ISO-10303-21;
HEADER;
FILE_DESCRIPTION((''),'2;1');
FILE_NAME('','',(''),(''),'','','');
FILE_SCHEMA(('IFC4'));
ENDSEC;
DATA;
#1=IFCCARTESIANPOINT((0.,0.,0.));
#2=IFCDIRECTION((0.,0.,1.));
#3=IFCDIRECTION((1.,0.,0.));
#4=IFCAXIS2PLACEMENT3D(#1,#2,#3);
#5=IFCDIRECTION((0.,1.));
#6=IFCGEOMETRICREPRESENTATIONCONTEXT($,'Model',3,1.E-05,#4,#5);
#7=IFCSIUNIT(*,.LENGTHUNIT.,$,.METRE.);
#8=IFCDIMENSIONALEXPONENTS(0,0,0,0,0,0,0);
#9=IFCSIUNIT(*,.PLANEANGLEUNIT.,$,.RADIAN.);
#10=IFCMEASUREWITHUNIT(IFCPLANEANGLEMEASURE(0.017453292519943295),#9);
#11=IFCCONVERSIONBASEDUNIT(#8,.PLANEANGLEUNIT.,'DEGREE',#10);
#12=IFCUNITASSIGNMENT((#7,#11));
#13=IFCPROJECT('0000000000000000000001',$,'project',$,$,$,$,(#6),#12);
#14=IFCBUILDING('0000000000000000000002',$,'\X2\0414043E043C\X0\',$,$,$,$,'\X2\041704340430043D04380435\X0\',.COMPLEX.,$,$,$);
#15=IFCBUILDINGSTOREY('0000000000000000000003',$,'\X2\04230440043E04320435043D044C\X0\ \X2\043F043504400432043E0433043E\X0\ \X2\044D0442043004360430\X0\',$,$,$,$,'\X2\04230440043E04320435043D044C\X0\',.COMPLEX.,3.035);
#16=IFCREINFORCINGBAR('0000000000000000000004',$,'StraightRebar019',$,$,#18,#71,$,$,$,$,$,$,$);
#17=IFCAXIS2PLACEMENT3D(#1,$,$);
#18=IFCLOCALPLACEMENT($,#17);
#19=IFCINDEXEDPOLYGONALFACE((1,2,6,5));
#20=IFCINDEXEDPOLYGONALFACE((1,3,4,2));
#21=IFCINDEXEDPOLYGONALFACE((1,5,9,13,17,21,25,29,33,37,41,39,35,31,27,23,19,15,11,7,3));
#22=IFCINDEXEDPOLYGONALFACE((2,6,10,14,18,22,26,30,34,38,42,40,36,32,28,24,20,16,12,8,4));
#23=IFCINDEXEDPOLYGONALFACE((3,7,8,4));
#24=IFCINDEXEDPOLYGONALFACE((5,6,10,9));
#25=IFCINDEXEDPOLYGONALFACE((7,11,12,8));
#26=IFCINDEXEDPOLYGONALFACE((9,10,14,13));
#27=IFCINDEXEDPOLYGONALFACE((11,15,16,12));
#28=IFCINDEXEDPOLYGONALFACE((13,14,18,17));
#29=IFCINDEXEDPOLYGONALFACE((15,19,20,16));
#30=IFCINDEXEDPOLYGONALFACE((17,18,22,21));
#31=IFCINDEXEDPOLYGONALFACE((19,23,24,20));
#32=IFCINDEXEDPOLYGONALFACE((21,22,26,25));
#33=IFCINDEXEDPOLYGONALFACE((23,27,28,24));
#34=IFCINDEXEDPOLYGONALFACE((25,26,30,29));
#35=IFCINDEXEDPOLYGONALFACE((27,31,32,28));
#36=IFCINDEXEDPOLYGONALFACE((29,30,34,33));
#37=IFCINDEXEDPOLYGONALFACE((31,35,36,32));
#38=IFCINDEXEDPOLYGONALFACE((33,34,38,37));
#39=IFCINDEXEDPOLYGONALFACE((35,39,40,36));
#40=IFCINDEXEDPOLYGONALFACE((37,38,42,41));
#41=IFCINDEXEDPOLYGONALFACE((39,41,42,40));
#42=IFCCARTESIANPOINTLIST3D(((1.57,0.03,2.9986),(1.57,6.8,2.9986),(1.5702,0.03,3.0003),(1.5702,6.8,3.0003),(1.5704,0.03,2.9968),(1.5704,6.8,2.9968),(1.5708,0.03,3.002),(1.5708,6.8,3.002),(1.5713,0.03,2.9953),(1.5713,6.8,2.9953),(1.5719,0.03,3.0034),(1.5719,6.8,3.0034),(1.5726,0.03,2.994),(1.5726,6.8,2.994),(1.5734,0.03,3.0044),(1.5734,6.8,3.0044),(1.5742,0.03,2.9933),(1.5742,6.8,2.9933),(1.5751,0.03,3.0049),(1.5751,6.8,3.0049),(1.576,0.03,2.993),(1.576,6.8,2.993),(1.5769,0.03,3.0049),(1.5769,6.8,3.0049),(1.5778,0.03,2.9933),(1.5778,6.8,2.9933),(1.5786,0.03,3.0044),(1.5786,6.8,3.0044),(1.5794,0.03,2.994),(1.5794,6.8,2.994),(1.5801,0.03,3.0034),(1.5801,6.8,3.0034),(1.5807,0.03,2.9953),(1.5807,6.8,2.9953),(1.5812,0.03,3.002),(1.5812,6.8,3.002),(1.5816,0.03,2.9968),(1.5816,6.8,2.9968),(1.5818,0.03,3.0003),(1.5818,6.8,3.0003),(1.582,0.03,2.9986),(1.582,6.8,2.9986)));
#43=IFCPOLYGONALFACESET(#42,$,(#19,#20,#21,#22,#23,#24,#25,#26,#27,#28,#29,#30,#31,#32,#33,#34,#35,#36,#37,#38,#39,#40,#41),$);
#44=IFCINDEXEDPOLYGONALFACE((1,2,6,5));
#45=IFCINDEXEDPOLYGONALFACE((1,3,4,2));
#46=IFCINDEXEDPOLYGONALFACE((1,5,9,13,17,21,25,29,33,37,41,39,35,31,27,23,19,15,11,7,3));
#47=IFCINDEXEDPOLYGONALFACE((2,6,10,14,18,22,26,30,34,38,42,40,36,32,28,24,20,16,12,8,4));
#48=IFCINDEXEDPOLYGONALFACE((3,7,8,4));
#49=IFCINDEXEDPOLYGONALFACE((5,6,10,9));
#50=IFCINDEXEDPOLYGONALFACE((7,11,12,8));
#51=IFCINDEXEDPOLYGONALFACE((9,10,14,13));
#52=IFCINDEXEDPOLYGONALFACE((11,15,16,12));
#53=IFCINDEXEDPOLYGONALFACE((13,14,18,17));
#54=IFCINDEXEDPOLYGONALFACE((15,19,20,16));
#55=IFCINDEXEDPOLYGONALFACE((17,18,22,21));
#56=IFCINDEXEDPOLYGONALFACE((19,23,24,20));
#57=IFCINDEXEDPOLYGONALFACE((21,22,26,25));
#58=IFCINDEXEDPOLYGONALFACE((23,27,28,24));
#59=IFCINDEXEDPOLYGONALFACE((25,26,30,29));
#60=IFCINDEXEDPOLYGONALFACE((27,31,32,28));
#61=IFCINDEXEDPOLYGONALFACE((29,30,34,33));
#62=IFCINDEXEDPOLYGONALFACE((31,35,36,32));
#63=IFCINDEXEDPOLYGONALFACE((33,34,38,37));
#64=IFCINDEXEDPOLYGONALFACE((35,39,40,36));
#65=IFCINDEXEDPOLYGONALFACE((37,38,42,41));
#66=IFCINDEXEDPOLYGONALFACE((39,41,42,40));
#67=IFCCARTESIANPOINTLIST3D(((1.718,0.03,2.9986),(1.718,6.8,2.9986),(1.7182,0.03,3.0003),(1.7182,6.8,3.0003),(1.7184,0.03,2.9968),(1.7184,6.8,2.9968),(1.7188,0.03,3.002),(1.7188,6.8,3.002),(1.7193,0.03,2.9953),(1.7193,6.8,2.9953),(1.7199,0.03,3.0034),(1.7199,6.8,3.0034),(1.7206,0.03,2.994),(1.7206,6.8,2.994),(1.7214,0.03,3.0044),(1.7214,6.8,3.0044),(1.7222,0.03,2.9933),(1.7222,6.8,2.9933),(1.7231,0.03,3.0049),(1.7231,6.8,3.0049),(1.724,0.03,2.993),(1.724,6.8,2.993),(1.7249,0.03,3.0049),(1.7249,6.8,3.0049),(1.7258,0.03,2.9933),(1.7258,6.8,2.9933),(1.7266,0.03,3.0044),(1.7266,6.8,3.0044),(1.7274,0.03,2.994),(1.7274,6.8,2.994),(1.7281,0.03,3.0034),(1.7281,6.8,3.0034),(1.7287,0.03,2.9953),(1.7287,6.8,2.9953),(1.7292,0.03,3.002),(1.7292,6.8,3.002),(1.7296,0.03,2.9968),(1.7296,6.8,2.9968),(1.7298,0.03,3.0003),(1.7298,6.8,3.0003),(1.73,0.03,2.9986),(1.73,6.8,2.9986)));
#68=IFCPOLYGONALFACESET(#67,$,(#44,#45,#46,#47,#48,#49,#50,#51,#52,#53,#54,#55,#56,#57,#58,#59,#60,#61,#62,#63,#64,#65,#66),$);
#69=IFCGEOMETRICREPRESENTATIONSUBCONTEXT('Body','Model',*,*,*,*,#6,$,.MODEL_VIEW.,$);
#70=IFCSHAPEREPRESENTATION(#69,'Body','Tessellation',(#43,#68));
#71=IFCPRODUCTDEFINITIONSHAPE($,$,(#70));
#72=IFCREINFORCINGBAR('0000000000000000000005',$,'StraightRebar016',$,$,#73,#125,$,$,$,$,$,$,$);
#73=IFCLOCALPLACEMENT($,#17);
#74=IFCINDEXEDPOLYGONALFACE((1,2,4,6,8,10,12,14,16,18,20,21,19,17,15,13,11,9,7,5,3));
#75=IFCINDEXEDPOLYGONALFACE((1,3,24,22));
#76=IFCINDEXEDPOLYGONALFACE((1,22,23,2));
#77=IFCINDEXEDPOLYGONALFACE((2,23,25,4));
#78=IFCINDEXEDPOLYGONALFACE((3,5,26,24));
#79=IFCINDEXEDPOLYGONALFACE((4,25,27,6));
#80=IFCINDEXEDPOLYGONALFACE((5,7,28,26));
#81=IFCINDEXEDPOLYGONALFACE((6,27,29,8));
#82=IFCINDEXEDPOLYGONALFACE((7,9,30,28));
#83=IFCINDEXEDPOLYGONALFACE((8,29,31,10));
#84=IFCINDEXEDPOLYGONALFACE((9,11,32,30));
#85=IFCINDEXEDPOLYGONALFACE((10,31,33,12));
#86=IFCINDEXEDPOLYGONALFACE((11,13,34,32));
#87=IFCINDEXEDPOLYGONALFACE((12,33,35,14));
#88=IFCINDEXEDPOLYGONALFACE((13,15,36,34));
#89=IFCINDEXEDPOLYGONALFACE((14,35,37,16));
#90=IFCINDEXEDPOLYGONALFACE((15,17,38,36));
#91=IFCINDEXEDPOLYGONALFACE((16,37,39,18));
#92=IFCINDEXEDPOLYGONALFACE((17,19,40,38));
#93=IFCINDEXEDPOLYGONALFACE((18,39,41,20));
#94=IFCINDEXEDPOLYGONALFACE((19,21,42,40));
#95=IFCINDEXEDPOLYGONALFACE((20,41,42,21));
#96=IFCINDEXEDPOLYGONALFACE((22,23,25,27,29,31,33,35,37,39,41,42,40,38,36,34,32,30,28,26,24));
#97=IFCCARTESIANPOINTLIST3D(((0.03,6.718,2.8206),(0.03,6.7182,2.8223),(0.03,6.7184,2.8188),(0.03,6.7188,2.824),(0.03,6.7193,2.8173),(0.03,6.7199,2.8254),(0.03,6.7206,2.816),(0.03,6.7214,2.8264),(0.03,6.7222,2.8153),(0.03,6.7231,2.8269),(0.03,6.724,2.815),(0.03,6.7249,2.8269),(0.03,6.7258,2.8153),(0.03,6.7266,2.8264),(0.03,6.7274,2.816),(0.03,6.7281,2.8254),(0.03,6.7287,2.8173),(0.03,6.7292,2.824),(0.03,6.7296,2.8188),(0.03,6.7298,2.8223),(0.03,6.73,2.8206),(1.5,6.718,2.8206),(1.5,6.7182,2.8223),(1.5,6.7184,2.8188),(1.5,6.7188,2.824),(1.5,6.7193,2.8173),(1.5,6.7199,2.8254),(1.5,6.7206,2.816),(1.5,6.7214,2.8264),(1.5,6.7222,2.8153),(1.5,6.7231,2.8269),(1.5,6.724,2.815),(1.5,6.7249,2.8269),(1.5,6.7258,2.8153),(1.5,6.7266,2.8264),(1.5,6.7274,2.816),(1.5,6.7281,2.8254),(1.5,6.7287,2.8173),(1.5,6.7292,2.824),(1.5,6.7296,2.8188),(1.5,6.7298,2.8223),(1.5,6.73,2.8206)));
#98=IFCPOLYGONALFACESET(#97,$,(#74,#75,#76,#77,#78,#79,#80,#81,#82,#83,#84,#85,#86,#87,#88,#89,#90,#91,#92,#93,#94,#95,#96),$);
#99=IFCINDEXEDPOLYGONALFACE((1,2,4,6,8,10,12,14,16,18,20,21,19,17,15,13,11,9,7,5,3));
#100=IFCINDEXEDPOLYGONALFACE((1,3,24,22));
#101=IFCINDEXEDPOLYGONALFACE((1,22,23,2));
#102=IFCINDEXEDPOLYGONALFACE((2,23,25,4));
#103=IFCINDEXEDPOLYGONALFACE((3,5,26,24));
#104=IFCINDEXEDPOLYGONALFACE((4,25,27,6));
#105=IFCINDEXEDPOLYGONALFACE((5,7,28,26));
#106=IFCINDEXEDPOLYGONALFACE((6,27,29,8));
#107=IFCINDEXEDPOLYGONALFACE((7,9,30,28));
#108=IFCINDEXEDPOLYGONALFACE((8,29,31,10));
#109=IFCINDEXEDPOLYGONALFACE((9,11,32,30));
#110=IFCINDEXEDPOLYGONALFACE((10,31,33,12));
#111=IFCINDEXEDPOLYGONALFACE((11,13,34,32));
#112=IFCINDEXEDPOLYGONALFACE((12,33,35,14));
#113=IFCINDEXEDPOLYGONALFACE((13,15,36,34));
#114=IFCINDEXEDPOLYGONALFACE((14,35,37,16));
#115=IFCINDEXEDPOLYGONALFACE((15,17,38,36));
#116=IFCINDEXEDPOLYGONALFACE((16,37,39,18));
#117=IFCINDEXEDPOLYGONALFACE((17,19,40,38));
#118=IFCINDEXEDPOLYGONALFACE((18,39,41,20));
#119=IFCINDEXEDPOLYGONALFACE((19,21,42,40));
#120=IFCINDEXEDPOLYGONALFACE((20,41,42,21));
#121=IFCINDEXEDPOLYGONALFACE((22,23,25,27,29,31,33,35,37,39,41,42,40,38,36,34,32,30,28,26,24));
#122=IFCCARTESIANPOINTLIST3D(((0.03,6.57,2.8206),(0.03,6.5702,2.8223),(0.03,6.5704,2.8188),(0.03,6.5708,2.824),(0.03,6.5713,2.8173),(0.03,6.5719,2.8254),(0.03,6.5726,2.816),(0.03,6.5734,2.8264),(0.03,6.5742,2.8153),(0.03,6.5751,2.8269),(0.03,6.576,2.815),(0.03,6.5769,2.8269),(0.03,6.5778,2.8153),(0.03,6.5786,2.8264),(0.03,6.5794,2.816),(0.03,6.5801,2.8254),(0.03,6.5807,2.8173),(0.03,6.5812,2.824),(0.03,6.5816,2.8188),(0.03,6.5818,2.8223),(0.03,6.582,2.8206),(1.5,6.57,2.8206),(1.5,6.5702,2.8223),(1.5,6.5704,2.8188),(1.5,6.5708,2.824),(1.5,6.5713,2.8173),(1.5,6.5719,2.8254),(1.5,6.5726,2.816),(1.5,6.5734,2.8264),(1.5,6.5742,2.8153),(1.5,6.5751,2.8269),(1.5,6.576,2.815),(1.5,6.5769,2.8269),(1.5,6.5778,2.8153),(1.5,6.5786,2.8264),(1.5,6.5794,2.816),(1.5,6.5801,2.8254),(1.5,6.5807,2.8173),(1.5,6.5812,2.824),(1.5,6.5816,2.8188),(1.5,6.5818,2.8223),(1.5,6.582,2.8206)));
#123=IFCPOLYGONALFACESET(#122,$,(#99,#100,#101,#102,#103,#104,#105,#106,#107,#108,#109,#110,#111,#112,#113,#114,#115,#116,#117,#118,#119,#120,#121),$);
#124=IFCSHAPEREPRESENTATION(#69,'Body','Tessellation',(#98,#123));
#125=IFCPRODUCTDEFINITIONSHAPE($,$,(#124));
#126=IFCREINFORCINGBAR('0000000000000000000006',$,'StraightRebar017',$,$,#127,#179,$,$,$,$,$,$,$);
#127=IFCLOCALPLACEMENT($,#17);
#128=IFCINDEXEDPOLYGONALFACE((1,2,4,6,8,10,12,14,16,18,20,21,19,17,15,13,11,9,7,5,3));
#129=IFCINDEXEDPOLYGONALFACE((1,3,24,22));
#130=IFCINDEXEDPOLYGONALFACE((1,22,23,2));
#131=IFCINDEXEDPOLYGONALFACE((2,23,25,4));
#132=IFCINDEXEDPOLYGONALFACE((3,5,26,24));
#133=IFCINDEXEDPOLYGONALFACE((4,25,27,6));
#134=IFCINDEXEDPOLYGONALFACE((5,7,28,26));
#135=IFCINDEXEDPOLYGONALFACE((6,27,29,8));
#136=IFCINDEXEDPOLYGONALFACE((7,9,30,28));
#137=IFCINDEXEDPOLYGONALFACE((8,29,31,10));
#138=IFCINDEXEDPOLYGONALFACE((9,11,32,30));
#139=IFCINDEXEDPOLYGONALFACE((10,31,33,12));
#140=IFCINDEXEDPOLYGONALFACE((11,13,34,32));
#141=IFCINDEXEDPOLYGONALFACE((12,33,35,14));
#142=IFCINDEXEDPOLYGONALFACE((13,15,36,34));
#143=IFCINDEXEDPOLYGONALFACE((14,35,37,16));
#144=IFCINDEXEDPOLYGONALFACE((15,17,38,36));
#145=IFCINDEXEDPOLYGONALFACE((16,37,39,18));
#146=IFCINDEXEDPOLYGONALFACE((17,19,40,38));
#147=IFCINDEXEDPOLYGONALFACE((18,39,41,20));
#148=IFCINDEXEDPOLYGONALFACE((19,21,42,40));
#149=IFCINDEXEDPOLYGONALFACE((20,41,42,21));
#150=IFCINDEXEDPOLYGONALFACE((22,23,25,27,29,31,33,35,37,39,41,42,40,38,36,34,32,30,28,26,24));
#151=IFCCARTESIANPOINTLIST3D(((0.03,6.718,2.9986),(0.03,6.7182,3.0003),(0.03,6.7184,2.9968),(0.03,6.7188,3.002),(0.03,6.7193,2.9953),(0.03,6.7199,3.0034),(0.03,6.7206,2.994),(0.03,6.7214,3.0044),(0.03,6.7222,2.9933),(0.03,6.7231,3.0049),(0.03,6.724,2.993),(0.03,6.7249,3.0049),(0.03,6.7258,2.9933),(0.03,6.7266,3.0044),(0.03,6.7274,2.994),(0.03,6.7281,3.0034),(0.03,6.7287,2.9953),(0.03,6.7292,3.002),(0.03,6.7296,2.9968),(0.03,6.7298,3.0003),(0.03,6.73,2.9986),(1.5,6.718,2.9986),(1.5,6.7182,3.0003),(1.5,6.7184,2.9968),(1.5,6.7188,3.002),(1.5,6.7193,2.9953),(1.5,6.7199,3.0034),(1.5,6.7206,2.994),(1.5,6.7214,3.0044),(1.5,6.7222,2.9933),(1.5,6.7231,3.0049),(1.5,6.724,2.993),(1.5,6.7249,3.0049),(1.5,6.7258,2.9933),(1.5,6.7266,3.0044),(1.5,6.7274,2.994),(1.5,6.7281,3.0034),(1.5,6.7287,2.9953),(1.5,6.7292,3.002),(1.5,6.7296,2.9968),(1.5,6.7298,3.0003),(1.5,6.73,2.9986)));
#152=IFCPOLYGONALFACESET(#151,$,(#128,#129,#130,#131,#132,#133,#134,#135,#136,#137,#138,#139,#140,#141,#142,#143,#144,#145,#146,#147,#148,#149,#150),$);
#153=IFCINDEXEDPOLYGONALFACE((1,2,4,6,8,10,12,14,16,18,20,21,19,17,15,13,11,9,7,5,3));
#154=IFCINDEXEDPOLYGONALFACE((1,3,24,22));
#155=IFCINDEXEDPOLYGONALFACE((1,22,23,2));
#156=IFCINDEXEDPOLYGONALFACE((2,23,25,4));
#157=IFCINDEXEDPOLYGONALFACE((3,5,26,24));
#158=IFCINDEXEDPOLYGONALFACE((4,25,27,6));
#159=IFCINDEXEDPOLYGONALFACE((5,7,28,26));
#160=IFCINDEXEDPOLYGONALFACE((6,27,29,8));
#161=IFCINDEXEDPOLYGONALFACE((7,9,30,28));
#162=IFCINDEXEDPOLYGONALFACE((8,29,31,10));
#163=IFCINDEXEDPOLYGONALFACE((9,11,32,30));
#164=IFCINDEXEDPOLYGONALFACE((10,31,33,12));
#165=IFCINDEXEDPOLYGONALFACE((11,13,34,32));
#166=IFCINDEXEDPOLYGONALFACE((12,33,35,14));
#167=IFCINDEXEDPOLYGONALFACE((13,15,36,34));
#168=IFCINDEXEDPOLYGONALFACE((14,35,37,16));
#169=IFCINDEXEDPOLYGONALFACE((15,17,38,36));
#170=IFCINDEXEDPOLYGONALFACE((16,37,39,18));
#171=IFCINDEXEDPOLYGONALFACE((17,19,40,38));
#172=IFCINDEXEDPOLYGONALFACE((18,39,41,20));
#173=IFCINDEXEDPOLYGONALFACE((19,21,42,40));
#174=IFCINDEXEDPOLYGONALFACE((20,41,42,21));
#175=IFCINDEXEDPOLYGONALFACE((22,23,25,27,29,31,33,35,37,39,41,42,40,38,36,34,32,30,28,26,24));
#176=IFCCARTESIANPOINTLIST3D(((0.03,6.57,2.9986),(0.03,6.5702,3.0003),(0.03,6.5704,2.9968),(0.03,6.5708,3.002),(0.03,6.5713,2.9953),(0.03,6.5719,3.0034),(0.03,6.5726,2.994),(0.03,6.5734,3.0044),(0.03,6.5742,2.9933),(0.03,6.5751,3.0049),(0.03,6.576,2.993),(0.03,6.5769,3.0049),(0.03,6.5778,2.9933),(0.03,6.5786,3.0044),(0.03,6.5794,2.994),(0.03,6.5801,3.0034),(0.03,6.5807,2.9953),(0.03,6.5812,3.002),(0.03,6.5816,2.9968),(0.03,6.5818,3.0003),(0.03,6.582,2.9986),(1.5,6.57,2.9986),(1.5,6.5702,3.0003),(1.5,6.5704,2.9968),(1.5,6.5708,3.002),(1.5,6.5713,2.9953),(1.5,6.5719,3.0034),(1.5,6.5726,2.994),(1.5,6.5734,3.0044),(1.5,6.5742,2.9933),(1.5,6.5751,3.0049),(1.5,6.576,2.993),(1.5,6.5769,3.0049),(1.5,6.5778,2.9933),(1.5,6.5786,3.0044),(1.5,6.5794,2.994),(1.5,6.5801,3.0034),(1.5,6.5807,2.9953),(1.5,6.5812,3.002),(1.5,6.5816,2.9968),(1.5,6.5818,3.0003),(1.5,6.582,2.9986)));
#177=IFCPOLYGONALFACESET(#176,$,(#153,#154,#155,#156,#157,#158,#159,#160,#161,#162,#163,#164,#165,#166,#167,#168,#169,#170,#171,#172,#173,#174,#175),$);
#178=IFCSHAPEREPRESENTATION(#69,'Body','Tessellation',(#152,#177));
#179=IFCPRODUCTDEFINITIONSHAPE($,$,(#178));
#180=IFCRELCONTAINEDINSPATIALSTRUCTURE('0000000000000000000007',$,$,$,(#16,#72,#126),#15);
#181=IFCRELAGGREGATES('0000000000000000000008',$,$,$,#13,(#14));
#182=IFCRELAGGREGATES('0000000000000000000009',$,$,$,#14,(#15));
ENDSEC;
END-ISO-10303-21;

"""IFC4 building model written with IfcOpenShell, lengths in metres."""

from ifc_helpers import new_model, entity, si_unit, converted_unit, direction, origin_with_axes, place, context, subcontext, project, spatial, element, save


model = new_model("IFC4")

# Units and contexts
model_context = context("Model", 3, precision=1e-05, world=origin_with_axes(), true_north=direction((0.0, 1.0)))
body_context = subcontext(model_context, "Body", "Model", "MODEL_VIEW")
ifc_project = project(units=[si_unit("LENGTHUNIT", "METRE"), converted_unit("PLANEANGLEUNIT", "DEGREE", entity("IfcPlaneAngleMeasure", 0.017453292519943295), si_unit("PLANEANGLEUNIT", "RADIAN"), dimensions=[0, 0, 0, 0, 0, 0, 0])], contexts=[model_context])

# Building, storey
building = spatial("IfcBuilding", under=ifc_project, Name="Дом", LongName="Здание", CompositionType="COMPLEX")
storey = spatial("IfcBuildingStorey", under=building, Name="Уровень первого этажа", LongName="Уровень", CompositionType="COMPLEX", Elevation=3.035)

# Shared definitions
placement = place(None, origin_with_axes())

# Reinforcing bars
element("IfcReinforcingBar", 1, at=placement, inside=storey, Name="StraightRebar019", context=body_context, shape_type="SweptSolid", body=[
    entity("IfcSweptDiskSolid", entity("IfcCompositeCurve", [entity("IfcCompositeCurveSegment", "CONTINUOUS", True, entity("IfcPolyline", [entity("IfcCartesianPoint", [1.576, 6.8, 2.999]), entity("IfcCartesianPoint", [1.576, 0.03, 2.999])]))], False), 0.006),
    entity("IfcSweptDiskSolid", entity("IfcCompositeCurve", [entity("IfcCompositeCurveSegment", "CONTINUOUS", True, entity("IfcPolyline", [entity("IfcCartesianPoint", [1.724, 6.8, 2.999]), entity("IfcCartesianPoint", [1.724, 0.03, 2.999])]))], False), 0.006),
])
element("IfcReinforcingBar", 2, at=placement, inside=storey, Name="StraightRebar016", context=body_context, shape_type="SweptSolid", body=[
    entity("IfcSweptDiskSolid", entity("IfcCompositeCurve", [entity("IfcCompositeCurveSegment", "CONTINUOUS", True, entity("IfcPolyline", [entity("IfcCartesianPoint", [1.5, 6.724, 2.821]), entity("IfcCartesianPoint", [0.03, 6.724, 2.821])]))], False), 0.006),
    entity("IfcSweptDiskSolid", entity("IfcCompositeCurve", [entity("IfcCompositeCurveSegment", "CONTINUOUS", True, entity("IfcPolyline", [entity("IfcCartesianPoint", [1.5, 6.576, 2.821]), entity("IfcCartesianPoint", [0.03, 6.576, 2.821])]))], False), 0.006),
])
element("IfcReinforcingBar", 3, at=placement, inside=storey, Name="StraightRebar017", context=body_context, shape_type="SweptSolid", body=[
    entity("IfcSweptDiskSolid", entity("IfcCompositeCurve", [entity("IfcCompositeCurveSegment", "CONTINUOUS", True, entity("IfcPolyline", [entity("IfcCartesianPoint", [1.5, 6.724, 2.999]), entity("IfcCartesianPoint", [0.03, 6.724, 2.999])]))], False), 0.006),
    entity("IfcSweptDiskSolid", entity("IfcCompositeCurve", [entity("IfcCompositeCurveSegment", "CONTINUOUS", True, entity("IfcPolyline", [entity("IfcCartesianPoint", [1.5, 6.576, 2.999]), entity("IfcCartesianPoint", [0.03, 6.576, 2.999])]))], False), 0.006),
])

save(model, "model.ifc")
